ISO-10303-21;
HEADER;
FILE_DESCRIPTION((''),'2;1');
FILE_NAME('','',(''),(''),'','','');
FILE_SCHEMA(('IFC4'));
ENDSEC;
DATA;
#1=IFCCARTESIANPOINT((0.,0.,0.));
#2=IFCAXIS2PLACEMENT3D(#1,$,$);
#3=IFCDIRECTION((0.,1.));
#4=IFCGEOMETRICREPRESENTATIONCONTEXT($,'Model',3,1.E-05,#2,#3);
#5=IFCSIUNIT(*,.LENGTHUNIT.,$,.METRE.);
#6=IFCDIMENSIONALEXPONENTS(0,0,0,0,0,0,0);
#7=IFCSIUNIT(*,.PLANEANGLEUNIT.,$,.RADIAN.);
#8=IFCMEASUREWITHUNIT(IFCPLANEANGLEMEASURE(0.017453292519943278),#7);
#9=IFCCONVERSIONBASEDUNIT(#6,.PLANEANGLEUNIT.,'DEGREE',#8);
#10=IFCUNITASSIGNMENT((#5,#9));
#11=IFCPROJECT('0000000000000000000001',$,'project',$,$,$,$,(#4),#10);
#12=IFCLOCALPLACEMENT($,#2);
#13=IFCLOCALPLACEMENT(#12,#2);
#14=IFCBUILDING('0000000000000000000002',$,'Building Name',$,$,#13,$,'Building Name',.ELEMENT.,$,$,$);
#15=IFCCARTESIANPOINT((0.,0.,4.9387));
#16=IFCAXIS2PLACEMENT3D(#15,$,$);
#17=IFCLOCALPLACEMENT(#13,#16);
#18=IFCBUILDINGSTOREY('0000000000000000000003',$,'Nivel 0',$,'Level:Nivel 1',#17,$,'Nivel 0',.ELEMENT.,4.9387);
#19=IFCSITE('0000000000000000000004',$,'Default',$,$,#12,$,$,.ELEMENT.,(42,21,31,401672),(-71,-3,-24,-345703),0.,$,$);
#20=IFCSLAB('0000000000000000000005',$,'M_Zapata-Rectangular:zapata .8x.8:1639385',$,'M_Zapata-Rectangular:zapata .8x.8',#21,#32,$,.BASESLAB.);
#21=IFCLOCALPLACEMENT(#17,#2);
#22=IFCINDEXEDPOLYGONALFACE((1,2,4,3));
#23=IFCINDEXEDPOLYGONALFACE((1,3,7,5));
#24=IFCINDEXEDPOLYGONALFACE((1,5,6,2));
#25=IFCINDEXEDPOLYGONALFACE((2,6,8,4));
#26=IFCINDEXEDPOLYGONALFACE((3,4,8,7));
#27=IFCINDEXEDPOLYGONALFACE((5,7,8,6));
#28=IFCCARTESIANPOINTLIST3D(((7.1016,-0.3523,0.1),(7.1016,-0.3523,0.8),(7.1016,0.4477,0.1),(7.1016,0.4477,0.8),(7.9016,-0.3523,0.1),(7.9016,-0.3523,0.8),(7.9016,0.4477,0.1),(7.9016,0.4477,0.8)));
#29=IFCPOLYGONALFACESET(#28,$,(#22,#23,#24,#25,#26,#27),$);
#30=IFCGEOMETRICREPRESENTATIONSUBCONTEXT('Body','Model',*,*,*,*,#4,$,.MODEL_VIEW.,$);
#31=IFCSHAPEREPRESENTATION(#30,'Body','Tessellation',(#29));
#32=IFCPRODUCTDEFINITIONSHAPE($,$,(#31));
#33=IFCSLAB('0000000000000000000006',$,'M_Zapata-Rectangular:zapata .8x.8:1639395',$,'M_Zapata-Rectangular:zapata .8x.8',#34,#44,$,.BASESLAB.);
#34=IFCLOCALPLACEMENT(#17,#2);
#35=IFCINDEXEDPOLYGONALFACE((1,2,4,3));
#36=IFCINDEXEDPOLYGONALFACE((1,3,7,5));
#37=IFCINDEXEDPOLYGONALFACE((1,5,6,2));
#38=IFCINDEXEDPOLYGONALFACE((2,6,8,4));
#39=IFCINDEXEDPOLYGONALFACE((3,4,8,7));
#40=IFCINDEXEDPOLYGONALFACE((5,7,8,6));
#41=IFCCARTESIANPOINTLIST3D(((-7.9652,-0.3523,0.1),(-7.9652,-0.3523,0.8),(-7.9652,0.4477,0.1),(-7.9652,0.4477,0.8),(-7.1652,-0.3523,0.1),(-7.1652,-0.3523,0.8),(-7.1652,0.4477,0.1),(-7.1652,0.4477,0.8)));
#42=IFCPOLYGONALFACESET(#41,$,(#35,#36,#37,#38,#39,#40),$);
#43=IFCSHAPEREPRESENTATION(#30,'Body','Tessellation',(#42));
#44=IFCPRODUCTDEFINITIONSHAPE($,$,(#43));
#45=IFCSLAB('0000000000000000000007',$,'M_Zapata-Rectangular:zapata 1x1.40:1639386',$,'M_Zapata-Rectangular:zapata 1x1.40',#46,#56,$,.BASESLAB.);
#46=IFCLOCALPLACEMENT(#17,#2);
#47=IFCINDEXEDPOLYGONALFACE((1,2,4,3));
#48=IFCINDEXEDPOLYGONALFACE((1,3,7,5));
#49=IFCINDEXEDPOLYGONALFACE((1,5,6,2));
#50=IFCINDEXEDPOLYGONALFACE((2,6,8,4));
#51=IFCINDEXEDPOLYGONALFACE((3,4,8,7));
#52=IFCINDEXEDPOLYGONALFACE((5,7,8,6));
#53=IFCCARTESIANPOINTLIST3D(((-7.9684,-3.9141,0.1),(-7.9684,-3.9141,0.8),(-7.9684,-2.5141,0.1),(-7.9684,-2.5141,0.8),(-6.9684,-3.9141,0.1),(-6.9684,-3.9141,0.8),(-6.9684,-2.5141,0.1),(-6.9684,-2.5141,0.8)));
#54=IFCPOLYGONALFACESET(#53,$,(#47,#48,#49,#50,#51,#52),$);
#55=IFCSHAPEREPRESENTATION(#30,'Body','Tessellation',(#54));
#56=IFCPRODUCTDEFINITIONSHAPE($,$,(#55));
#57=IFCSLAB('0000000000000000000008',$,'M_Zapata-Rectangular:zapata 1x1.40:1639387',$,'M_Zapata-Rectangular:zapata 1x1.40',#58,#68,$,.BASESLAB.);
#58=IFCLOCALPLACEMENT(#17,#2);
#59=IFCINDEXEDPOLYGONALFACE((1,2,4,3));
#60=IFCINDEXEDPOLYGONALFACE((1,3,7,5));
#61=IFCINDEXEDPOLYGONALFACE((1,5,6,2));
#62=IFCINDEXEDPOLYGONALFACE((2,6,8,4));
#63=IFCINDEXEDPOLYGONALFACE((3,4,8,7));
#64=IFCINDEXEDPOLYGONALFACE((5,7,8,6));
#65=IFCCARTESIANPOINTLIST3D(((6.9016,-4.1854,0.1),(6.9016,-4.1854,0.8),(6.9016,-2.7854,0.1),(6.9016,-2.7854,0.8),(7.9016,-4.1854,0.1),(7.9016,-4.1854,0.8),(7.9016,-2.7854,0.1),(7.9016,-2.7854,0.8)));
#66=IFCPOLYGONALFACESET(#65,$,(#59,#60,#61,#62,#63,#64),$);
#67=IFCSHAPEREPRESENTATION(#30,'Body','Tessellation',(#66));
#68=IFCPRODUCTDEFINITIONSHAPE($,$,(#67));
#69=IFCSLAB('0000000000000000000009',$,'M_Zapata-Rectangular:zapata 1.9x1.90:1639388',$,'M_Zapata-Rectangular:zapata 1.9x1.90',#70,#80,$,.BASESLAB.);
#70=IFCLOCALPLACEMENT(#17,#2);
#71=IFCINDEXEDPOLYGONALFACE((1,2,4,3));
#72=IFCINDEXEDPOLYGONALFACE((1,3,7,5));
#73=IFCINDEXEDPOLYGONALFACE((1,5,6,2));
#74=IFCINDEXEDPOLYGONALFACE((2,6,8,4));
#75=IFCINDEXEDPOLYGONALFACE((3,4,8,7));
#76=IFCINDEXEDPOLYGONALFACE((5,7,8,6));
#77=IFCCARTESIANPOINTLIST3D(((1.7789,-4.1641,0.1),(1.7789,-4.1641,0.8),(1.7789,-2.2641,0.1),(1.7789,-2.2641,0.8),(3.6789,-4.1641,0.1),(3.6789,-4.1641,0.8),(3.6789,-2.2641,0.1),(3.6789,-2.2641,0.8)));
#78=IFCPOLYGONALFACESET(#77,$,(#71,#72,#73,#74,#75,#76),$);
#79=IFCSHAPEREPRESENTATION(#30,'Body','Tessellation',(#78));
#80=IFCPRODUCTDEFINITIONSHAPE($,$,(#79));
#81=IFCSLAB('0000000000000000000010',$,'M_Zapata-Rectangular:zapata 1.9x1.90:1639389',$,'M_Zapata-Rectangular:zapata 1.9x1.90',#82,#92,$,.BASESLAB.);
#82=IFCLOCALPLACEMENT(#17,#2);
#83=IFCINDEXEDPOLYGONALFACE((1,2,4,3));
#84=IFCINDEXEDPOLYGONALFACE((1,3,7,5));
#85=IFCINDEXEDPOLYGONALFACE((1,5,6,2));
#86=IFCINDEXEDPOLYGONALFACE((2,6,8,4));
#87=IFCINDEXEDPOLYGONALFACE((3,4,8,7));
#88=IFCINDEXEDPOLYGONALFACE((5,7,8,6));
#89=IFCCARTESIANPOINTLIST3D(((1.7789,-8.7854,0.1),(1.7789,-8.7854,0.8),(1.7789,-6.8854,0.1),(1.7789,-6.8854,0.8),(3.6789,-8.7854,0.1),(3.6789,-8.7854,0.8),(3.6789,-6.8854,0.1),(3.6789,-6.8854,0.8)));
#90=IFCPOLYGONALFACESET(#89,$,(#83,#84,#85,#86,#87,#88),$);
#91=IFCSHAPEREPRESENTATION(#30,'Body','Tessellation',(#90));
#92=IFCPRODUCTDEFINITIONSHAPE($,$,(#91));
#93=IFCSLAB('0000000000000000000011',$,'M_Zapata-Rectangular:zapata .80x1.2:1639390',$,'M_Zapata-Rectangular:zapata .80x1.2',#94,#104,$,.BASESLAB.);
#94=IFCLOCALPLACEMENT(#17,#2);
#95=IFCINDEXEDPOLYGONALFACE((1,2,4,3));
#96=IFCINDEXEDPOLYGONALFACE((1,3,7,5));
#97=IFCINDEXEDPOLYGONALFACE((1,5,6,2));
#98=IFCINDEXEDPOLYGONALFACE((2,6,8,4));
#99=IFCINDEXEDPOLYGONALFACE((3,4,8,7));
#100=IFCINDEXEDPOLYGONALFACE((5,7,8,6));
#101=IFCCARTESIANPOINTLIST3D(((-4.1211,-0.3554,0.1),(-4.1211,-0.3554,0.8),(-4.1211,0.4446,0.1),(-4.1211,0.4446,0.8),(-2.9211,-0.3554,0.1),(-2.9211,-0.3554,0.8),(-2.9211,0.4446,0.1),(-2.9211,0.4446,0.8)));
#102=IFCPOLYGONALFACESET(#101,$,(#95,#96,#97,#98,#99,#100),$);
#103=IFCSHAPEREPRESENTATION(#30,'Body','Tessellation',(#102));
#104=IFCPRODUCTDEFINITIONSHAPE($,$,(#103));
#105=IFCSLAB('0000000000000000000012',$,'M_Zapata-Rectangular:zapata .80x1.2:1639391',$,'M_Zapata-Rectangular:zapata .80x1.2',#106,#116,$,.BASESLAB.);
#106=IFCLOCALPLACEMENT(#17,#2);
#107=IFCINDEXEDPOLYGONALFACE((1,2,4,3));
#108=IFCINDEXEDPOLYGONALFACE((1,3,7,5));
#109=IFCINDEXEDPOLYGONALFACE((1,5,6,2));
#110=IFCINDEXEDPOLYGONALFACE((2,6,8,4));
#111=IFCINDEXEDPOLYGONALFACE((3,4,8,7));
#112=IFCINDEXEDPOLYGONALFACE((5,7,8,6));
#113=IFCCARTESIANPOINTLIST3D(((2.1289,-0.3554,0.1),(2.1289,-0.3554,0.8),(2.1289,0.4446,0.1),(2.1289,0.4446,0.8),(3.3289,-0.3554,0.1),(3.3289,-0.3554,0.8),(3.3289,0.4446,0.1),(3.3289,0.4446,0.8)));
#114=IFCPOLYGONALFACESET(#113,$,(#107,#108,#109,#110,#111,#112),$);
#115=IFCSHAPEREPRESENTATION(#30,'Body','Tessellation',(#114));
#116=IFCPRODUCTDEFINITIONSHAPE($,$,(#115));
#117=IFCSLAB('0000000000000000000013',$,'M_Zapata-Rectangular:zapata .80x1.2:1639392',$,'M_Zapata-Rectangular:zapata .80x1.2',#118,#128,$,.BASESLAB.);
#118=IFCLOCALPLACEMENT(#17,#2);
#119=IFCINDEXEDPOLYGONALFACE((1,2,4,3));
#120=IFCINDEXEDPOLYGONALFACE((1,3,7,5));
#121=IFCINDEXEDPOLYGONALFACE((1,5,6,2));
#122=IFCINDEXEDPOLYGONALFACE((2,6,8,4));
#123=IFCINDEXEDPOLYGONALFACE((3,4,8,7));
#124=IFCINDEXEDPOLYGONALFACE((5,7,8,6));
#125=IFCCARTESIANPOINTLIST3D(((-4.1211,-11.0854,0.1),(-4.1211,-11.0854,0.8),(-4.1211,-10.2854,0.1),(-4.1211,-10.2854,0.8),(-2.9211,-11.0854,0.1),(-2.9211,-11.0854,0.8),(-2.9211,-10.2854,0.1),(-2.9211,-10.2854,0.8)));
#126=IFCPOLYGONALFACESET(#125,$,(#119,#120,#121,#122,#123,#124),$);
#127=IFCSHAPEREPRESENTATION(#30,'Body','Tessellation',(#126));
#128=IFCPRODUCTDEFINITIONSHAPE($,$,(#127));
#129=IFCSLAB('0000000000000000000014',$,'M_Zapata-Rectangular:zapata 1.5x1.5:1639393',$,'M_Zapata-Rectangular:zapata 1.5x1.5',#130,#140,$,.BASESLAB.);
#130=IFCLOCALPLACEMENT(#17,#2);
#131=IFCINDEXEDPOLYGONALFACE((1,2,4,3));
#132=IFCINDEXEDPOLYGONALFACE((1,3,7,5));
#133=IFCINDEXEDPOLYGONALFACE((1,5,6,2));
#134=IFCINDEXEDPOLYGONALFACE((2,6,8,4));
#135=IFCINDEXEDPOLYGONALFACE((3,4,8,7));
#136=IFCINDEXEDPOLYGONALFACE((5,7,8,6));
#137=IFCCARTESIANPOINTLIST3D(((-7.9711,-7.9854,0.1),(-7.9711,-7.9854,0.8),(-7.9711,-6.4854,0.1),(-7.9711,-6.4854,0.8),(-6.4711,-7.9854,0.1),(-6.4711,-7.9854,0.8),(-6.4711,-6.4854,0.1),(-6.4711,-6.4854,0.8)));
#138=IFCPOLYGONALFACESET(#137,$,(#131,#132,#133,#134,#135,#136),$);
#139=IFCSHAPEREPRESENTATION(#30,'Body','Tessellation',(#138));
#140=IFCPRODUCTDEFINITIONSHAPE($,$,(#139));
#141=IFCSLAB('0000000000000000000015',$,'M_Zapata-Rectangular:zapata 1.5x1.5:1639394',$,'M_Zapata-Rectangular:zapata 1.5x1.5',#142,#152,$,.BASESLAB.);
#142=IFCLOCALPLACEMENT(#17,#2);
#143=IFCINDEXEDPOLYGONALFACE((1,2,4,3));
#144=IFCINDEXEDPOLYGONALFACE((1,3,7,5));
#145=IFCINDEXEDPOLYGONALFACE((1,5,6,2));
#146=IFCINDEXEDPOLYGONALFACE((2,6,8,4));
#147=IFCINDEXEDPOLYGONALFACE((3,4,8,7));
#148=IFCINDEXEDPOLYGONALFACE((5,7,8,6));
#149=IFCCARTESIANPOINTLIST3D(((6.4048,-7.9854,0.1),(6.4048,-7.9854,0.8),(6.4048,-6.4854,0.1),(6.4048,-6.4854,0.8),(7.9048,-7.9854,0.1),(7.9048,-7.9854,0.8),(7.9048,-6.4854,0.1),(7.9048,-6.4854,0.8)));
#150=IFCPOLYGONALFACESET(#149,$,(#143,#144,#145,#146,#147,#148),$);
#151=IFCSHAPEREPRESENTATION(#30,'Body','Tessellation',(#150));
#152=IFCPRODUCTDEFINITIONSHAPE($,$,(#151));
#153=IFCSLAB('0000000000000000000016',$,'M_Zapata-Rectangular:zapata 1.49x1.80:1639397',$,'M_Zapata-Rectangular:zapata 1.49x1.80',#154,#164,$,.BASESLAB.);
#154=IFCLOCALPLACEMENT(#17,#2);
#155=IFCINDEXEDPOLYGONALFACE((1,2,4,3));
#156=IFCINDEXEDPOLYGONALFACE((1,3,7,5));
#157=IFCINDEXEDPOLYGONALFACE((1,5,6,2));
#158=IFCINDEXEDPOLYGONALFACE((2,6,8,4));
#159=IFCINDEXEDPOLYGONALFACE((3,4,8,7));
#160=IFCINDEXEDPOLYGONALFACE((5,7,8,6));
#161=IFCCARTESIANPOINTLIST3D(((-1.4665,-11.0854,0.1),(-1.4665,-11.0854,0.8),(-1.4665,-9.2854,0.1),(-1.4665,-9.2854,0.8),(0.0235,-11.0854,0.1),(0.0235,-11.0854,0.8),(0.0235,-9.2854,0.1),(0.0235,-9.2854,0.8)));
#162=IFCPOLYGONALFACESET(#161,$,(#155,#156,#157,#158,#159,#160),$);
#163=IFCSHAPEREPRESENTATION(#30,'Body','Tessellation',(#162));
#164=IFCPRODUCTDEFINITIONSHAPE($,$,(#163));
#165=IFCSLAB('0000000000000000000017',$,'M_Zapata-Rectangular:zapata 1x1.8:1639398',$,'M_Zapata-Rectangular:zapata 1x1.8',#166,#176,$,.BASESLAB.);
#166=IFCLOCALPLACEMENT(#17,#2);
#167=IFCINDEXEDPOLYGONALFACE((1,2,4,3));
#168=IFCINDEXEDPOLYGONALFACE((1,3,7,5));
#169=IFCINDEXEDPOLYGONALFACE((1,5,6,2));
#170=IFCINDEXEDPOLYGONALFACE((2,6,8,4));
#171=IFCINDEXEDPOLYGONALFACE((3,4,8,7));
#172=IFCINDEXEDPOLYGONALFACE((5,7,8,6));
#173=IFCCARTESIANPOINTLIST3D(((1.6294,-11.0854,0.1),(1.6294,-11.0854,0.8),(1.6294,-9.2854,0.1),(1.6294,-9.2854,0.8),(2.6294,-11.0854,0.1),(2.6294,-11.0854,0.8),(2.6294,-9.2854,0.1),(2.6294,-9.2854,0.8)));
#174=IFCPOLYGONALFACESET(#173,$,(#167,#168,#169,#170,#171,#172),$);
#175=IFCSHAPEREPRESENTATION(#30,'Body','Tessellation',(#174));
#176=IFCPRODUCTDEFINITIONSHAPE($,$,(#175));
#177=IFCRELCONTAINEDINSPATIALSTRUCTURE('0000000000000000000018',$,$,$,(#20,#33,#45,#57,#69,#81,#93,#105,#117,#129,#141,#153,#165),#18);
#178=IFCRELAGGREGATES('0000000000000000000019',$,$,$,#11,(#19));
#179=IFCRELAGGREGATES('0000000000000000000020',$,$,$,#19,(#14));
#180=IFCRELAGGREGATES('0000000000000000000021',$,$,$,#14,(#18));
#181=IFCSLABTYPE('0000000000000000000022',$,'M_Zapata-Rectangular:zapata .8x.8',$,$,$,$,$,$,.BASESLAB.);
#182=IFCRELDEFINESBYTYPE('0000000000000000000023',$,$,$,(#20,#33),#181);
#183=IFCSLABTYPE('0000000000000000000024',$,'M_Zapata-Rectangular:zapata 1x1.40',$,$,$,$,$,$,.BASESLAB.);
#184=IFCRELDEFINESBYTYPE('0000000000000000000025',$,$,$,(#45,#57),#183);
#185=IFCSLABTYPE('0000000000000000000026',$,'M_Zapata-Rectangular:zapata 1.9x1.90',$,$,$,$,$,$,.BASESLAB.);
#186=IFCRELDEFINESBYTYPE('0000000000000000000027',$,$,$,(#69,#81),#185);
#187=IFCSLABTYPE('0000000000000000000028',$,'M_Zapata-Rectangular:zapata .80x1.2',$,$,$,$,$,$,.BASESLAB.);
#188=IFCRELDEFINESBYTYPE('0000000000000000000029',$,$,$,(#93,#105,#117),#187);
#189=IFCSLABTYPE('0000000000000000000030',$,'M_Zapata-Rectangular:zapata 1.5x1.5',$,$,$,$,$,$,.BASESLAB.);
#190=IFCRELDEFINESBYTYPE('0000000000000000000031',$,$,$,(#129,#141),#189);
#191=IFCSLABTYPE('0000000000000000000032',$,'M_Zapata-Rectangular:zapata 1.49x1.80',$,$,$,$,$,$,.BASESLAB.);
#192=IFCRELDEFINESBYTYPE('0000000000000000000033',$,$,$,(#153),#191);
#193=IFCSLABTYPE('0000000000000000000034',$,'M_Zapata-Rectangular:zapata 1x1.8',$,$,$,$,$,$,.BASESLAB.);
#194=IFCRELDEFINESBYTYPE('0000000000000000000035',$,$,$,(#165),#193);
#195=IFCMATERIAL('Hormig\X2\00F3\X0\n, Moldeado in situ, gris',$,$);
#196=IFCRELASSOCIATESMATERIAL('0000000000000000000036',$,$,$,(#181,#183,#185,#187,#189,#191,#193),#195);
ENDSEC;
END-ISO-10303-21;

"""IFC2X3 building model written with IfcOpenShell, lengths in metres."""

from ifc_helpers import new_model, entity, si_unit, converted_unit, direction, frame, frame_2d, origin, origin_2d_with_axis, place, context, subcontext, project, spatial, rectangle, extrude, material, type_object, element, save


model = new_model("IFC2X3")

# Units and contexts
model_context = context("Model", 3, precision=1e-05, world=origin(), true_north=direction((0.0, 1.0)))
body_context = subcontext(model_context, "Body", "Model", "MODEL_VIEW")
ifc_project = project(units=[si_unit("LENGTHUNIT", "METRE"), converted_unit("PLANEANGLEUNIT", "DEGREE", entity("IfcPlaneAngleMeasure", 0.017453292519943278), si_unit("PLANEANGLEUNIT", "RADIAN"), dimensions=[0, 0, 0, 0, 0, 0, 0])], contexts=[model_context])

# Site, building, storey
site_placement = place(None, origin())
site = spatial("IfcSite", under=ifc_project, at=site_placement, Name="Default", CompositionType="ELEMENT", RefLatitude=(42, 21, 31, 401672), RefLongitude=(-71, -3, -24, -345703), RefElevation=0.0)
building_placement = place(site_placement, origin())
building = spatial("IfcBuilding", under=site, at=building_placement, Name="Building Name", LongName="Building Name", CompositionType="ELEMENT")
storey_placement = place(building_placement, frame((0.0, 0.0, 4.9387)))
storey = spatial("IfcBuildingStorey", under=building, at=storey_placement, Name="Nivel 0", ObjectType="Level:Nivel 1", LongName="Nivel 0", CompositionType="ELEMENT", Elevation=4.9387)

# Slabs
ifc_material = material(Name="Hormigón, Moldeado in situ, gris")
slab_type_1 = type_object("IfcSlabType", Name="M_Zapata-Rectangular:zapata .8x.8", PredefinedType="BASESLAB", material=ifc_material)
slab_1_placement = place(storey_placement, origin())
element("IfcSlab", 1, at=slab_1_placement, inside=storey, type_object=slab_type_1, Name="M_Zapata-Rectangular:zapata .8x.8:1639385", ObjectType="M_Zapata-Rectangular:zapata .8x.8", PredefinedType="BASESLAB", context=body_context, shape_type="SweptSolid", body=[
    extrude(rectangle(XDim=0.8, YDim=0.8, at=origin_2d_with_axis()), frame((7.5016, 0.0477, 0.1), z_axis=(0.0, 0.0, 1.0), x_axis=(-1.0, 0.0, 0.0)), (0.0, 0.0, 1.0), 0.7),
])
slab_2_placement = place(storey_placement, origin())
element("IfcSlab", 2, at=slab_2_placement, inside=storey, type_object=slab_type_1, Name="M_Zapata-Rectangular:zapata .8x.8:1639395", ObjectType="M_Zapata-Rectangular:zapata .8x.8", PredefinedType="BASESLAB", context=body_context, shape_type="SweptSolid", body=[
    extrude(rectangle(XDim=0.8, YDim=0.8, at=origin_2d_with_axis()), frame((-7.5652, 0.0477, 0.1), z_axis=(0.0, 0.0, 1.0), x_axis=(-1.0, 0.0, 0.0)), (0.0, 0.0, 1.0), 0.7),
])
slab_type_2 = type_object("IfcSlabType", Name="M_Zapata-Rectangular:zapata 1x1.40", PredefinedType="BASESLAB", material=ifc_material)
slab_3_placement = place(storey_placement, origin())
element("IfcSlab", 3, at=slab_3_placement, inside=storey, type_object=slab_type_2, Name="M_Zapata-Rectangular:zapata 1x1.40:1639386", ObjectType="M_Zapata-Rectangular:zapata 1x1.40", PredefinedType="BASESLAB", context=body_context, shape_type="SweptSolid", body=[
    extrude(rectangle(XDim=1.0, YDim=1.4, at=frame_2d((0.0, 0.0), x_axis=(1.0, 0.0))), frame((-7.4684, -3.2141, 0.1), z_axis=(0.0, 0.0, 1.0), x_axis=(-1.0, 0.0, 0.0)), (0.0, 0.0, 1.0), 0.7),
])
slab_4_placement = place(storey_placement, origin())
element("IfcSlab", 4, at=slab_4_placement, inside=storey, type_object=slab_type_2, Name="M_Zapata-Rectangular:zapata 1x1.40:1639387", ObjectType="M_Zapata-Rectangular:zapata 1x1.40", PredefinedType="BASESLAB", context=body_context, shape_type="SweptSolid", body=[
    extrude(rectangle(XDim=1.0, YDim=1.4, at=frame_2d((0.0, 0.0), x_axis=(1.0, 0.0))), frame((7.4016, -3.4854, 0.1), z_axis=(0.0, 0.0, 1.0), x_axis=(-1.0, 0.0, 0.0)), (0.0, 0.0, 1.0), 0.7),
])
slab_type_3 = type_object("IfcSlabType", Name="M_Zapata-Rectangular:zapata 1.9x1.90", PredefinedType="BASESLAB", material=ifc_material)
slab_5_placement = place(storey_placement, origin())
element("IfcSlab", 5, at=slab_5_placement, inside=storey, type_object=slab_type_3, Name="M_Zapata-Rectangular:zapata 1.9x1.90:1639388", ObjectType="M_Zapata-Rectangular:zapata 1.9x1.90", PredefinedType="BASESLAB", context=body_context, shape_type="SweptSolid", body=[
    extrude(rectangle(XDim=1.9, YDim=1.9, at=frame_2d((0.0, 0.0), x_axis=(1.0, 0.0))), frame((2.7289, -3.2141, 0.1), z_axis=(0.0, 0.0, 1.0), x_axis=(-1.0, 0.0, 0.0)), (0.0, 0.0, 1.0), 0.7),
])
slab_6_placement = place(storey_placement, origin())
element("IfcSlab", 6, at=slab_6_placement, inside=storey, type_object=slab_type_3, Name="M_Zapata-Rectangular:zapata 1.9x1.90:1639389", ObjectType="M_Zapata-Rectangular:zapata 1.9x1.90", PredefinedType="BASESLAB", context=body_context, shape_type="SweptSolid", body=[
    extrude(rectangle(XDim=1.9, YDim=1.9, at=frame_2d((0.0, 0.0), x_axis=(1.0, 0.0))), frame((2.7289, -7.8354, 0.1), z_axis=(0.0, 0.0, 1.0), x_axis=(-1.0, 0.0, 0.0)), (0.0, 0.0, 1.0), 0.7),
])
slab_type_4 = type_object("IfcSlabType", Name="M_Zapata-Rectangular:zapata .80x1.2", PredefinedType="BASESLAB", material=ifc_material)
slab_7_placement = place(storey_placement, origin())
element("IfcSlab", 7, at=slab_7_placement, inside=storey, type_object=slab_type_4, Name="M_Zapata-Rectangular:zapata .80x1.2:1639390", ObjectType="M_Zapata-Rectangular:zapata .80x1.2", PredefinedType="BASESLAB", context=body_context, shape_type="SweptSolid", body=[
    extrude(rectangle(XDim=0.8, YDim=1.2, at=origin_2d_with_axis()), frame((-3.5211, 0.0446, 0.1), z_axis=(0.0, 0.0, 1.0), x_axis=(0.0, 1.0, 0.0)), (0.0, 0.0, 1.0), 0.7),
])
slab_8_placement = place(storey_placement, origin())
element("IfcSlab", 8, at=slab_8_placement, inside=storey, type_object=slab_type_4, Name="M_Zapata-Rectangular:zapata .80x1.2:1639391", ObjectType="M_Zapata-Rectangular:zapata .80x1.2", PredefinedType="BASESLAB", context=body_context, shape_type="SweptSolid", body=[
    extrude(rectangle(XDim=0.8, YDim=1.2, at=origin_2d_with_axis()), frame((2.7289, 0.0446, 0.1), z_axis=(0.0, 0.0, 1.0), x_axis=(0.0, 1.0, 0.0)), (0.0, 0.0, 1.0), 0.7),
])
slab_9_placement = place(storey_placement, origin())
element("IfcSlab", 9, at=slab_9_placement, inside=storey, type_object=slab_type_4, Name="M_Zapata-Rectangular:zapata .80x1.2:1639392", ObjectType="M_Zapata-Rectangular:zapata .80x1.2", PredefinedType="BASESLAB", context=body_context, shape_type="SweptSolid", body=[
    extrude(rectangle(XDim=0.8, YDim=1.2, at=origin_2d_with_axis()), frame((-3.5211, -10.6854, 0.1), z_axis=(0.0, 0.0, 1.0), x_axis=(0.0, 1.0, 0.0)), (0.0, 0.0, 1.0), 0.7),
])
slab_type_5 = type_object("IfcSlabType", Name="M_Zapata-Rectangular:zapata 1.5x1.5", PredefinedType="BASESLAB", material=ifc_material)
slab_10_placement = place(storey_placement, origin())
element("IfcSlab", 10, at=slab_10_placement, inside=storey, type_object=slab_type_5, Name="M_Zapata-Rectangular:zapata 1.5x1.5:1639393", ObjectType="M_Zapata-Rectangular:zapata 1.5x1.5", PredefinedType="BASESLAB", context=body_context, shape_type="SweptSolid", body=[
    extrude(rectangle(XDim=1.5, YDim=1.5, at=frame_2d((0.0, 0.0), x_axis=(1.0, 0.0))), frame((-7.2211, -7.2354, 0.1), z_axis=(0.0, 0.0, 1.0), x_axis=(-1.0, 0.0, 0.0)), (0.0, 0.0, 1.0), 0.7),
])
slab_11_placement = place(storey_placement, origin())
element("IfcSlab", 11, at=slab_11_placement, inside=storey, type_object=slab_type_5, Name="M_Zapata-Rectangular:zapata 1.5x1.5:1639394", ObjectType="M_Zapata-Rectangular:zapata 1.5x1.5", PredefinedType="BASESLAB", context=body_context, shape_type="SweptSolid", body=[
    extrude(rectangle(XDim=1.5, YDim=1.5, at=frame_2d((0.0, 0.0), x_axis=(1.0, 0.0))), frame((7.1548, -7.2354, 0.1), z_axis=(0.0, 0.0, 1.0), x_axis=(-1.0, 0.0, 0.0)), (0.0, 0.0, 1.0), 0.7),
])
slab_type_6 = type_object("IfcSlabType", Name="M_Zapata-Rectangular:zapata 1.49x1.80", PredefinedType="BASESLAB", material=ifc_material)
slab_12_placement = place(storey_placement, origin())
element("IfcSlab", 12, at=slab_12_placement, inside=storey, type_object=slab_type_6, Name="M_Zapata-Rectangular:zapata 1.49x1.80:1639397", ObjectType="M_Zapata-Rectangular:zapata 1.49x1.80", PredefinedType="BASESLAB", context=body_context, shape_type="SweptSolid", body=[
    extrude(rectangle(XDim=1.49, YDim=1.8, at=frame_2d((0.0, 0.0), x_axis=(1.0, 0.0))), frame((-0.7215, -10.1854, 0.1), z_axis=(0.0, 0.0, 1.0), x_axis=(-1.0, 0.0, 0.0)), (0.0, 0.0, 1.0), 0.7),
])
slab_type_7 = type_object("IfcSlabType", Name="M_Zapata-Rectangular:zapata 1x1.8", PredefinedType="BASESLAB", material=ifc_material)
slab_13_placement = place(storey_placement, origin())
element("IfcSlab", 13, at=slab_13_placement, inside=storey, type_object=slab_type_7, Name="M_Zapata-Rectangular:zapata 1x1.8:1639398", ObjectType="M_Zapata-Rectangular:zapata 1x1.8", PredefinedType="BASESLAB", context=body_context, shape_type="SweptSolid", body=[
    extrude(rectangle(XDim=1.0, YDim=1.8, at=frame_2d((0.0, 0.0), x_axis=(1.0, 0.0))), frame((2.1294, -10.1854, 0.1), z_axis=(0.0, 0.0, 1.0), x_axis=(-1.0, 0.0, 0.0)), (0.0, 0.0, 1.0), 0.7),
])

save(model, "model.ifc")
